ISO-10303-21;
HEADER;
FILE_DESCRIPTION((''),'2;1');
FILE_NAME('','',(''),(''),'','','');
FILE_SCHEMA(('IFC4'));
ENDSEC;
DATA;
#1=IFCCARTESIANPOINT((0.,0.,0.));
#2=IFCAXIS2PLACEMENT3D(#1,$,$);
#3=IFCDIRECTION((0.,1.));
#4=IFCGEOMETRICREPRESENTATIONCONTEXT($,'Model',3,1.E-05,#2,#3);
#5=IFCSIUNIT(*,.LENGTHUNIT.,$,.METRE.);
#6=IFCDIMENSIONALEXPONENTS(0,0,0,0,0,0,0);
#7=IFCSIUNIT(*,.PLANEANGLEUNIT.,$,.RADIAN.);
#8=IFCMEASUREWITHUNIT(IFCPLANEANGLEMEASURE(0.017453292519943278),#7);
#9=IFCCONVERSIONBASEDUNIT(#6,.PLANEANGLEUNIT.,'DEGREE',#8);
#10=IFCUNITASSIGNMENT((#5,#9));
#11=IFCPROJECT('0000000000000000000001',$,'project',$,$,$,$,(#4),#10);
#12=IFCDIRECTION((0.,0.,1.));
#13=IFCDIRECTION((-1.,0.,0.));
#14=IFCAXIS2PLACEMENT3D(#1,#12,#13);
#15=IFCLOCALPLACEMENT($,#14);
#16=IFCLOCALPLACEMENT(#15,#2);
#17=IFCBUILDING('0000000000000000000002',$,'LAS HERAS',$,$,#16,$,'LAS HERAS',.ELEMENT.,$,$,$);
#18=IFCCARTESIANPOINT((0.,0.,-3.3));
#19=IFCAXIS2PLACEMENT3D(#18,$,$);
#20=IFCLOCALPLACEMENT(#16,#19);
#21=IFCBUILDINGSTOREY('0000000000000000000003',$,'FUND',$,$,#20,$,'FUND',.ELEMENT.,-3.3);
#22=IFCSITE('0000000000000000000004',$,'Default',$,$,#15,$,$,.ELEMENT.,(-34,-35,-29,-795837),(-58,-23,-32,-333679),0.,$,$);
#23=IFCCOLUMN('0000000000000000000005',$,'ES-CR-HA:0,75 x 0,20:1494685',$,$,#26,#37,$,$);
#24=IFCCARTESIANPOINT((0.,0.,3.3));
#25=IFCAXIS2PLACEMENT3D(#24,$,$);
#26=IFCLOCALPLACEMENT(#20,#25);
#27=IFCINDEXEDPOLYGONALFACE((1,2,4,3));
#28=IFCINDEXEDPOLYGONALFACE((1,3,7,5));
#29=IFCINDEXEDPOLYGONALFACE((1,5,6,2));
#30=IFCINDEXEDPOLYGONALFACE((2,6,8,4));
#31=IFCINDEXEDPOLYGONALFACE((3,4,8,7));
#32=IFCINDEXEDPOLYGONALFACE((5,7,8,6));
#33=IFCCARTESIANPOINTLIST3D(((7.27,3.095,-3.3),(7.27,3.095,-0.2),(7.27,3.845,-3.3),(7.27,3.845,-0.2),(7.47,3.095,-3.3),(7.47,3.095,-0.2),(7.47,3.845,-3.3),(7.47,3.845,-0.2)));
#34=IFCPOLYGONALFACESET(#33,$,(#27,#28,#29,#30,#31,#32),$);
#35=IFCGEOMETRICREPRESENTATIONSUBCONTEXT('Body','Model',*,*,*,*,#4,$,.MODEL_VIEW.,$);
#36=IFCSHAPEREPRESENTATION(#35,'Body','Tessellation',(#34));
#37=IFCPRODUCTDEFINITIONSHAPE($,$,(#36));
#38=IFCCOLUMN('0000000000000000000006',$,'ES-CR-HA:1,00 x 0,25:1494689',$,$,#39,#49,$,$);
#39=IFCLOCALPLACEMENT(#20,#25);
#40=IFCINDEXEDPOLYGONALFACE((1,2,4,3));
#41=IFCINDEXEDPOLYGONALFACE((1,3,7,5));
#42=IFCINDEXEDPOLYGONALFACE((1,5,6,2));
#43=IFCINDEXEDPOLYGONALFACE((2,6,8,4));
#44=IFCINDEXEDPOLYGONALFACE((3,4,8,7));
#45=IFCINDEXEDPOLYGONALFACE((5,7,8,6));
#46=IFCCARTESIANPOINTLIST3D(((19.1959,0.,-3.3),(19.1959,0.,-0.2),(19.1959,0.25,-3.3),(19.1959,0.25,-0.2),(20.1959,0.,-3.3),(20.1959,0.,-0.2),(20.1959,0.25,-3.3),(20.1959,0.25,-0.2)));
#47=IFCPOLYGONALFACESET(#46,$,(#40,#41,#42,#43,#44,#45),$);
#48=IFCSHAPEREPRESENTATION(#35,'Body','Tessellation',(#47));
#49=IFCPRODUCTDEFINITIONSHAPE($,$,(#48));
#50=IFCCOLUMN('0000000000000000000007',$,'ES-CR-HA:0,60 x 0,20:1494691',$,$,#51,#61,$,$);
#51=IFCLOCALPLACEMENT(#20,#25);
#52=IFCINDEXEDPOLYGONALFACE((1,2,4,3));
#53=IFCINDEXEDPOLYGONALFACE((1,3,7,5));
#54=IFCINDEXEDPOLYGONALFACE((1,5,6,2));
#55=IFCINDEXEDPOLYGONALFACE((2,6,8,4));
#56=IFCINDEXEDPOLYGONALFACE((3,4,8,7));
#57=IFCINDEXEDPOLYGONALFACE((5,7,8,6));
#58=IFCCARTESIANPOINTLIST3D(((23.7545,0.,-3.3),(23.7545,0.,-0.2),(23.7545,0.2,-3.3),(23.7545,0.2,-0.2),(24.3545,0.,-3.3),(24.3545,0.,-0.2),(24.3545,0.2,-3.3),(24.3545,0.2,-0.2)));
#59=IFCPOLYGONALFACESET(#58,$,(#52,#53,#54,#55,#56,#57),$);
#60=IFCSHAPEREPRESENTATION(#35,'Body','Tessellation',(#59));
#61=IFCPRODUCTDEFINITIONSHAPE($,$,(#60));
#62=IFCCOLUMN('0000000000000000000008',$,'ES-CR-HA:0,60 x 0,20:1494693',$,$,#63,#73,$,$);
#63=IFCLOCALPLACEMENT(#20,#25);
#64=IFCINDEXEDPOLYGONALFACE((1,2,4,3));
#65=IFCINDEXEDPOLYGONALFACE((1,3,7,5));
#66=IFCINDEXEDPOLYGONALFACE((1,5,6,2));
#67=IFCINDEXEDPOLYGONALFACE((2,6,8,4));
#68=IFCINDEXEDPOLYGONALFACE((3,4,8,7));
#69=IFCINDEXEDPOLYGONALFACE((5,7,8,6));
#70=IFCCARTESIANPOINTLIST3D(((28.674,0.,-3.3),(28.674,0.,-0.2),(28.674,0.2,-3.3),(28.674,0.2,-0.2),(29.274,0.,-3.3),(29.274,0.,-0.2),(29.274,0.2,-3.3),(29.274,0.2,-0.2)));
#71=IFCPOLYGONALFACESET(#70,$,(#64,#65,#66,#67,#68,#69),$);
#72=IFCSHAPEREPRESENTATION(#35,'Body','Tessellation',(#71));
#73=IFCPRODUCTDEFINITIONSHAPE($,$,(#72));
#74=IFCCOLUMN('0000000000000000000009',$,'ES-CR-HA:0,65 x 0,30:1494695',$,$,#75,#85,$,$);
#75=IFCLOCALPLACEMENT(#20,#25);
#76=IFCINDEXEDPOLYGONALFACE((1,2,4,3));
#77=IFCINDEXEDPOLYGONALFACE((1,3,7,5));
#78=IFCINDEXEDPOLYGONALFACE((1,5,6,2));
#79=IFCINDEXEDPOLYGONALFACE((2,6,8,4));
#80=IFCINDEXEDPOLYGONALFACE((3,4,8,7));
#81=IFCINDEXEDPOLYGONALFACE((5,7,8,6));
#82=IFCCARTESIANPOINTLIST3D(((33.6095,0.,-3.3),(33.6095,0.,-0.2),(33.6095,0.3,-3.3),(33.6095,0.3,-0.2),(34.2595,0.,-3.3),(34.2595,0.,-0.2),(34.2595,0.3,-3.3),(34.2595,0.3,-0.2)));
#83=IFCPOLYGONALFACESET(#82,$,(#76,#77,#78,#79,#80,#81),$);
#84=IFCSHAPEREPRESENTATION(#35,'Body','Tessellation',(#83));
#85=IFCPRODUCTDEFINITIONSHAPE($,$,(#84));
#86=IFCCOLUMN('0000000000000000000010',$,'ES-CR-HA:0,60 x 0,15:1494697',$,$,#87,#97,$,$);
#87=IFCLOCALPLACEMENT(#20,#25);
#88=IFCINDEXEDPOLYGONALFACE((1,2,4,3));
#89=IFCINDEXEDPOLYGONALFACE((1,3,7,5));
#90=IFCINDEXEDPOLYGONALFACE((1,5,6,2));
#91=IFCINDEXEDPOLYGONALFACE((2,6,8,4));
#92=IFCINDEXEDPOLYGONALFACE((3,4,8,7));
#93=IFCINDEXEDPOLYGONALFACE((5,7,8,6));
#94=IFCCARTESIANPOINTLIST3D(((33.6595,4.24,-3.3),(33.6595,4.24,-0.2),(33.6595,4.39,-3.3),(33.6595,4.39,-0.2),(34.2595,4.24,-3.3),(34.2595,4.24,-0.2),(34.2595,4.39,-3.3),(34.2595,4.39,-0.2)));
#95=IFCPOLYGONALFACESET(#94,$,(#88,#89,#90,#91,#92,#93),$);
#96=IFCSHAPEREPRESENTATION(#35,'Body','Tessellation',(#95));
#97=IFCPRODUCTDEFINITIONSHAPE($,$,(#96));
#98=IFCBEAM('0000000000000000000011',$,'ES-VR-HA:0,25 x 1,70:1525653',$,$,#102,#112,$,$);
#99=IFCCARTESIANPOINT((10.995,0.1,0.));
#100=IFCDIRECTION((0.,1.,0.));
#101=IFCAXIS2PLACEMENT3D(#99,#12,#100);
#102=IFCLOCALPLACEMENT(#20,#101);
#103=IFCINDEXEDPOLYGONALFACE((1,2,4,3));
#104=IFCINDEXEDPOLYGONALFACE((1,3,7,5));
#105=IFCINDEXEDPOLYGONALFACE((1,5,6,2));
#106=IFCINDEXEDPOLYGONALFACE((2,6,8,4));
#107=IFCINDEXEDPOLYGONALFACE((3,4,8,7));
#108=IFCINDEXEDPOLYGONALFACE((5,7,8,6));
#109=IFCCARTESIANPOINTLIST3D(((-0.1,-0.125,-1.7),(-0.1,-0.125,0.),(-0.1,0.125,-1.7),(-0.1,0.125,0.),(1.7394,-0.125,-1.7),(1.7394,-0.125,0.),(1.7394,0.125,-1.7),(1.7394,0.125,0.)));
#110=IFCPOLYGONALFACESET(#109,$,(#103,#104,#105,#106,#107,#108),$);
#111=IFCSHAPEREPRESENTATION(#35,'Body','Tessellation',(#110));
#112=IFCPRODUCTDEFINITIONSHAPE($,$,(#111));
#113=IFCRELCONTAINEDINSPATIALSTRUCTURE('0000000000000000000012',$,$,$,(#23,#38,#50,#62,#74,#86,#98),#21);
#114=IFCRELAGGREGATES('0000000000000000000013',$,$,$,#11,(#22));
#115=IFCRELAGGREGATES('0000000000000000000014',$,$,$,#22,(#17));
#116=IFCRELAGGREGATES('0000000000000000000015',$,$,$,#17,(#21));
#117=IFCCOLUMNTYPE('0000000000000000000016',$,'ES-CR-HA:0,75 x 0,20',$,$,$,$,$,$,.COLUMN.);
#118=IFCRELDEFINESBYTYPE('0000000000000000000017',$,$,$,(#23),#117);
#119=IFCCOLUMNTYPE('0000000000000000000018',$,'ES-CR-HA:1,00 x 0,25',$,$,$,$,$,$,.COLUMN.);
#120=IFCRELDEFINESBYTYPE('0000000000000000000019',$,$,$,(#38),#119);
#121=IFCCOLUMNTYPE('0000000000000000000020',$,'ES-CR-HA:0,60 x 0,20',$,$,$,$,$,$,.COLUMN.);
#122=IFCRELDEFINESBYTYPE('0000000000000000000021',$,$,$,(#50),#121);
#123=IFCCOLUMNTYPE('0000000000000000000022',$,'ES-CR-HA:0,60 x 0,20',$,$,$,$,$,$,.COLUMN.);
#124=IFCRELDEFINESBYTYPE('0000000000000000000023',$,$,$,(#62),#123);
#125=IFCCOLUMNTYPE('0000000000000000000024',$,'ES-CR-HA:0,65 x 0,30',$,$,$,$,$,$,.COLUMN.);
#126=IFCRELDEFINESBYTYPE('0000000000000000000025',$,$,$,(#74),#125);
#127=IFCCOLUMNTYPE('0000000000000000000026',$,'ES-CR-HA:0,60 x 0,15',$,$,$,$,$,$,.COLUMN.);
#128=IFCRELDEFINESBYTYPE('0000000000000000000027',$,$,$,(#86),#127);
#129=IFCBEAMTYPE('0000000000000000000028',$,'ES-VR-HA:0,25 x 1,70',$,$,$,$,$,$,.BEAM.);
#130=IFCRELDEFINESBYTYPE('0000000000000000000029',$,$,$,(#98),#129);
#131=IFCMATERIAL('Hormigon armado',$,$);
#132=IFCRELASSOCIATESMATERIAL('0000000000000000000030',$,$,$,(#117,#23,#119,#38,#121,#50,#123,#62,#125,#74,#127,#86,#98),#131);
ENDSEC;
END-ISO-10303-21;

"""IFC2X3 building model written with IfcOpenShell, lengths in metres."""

from ifc_helpers import new_model, entity, si_unit, converted_unit, direction, frame, frame_2d, origin, origin_2d_with_axis, place, context, subcontext, project, spatial, rectangle, extrude, source, transform, mapped, material, type_object, type_shapes, element, save


model = new_model("IFC2X3")

# Units and contexts
model_context = context("Model", 3, precision=1e-05, world=origin(), true_north=direction((0.0, 1.0)))
body_context = subcontext(model_context, "Body", "Model", "MODEL_VIEW")
ifc_project = project(units=[si_unit("LENGTHUNIT", "METRE"), converted_unit("PLANEANGLEUNIT", "DEGREE", entity("IfcPlaneAngleMeasure", 0.017453292519943278), si_unit("PLANEANGLEUNIT", "RADIAN"), dimensions=[0, 0, 0, 0, 0, 0, 0])], contexts=[model_context])

# Site, building, storey
site_placement = place(None, frame((0.0, 0.0, 0.0), z_axis=(0.0, 0.0, 1.0), x_axis=(-1.0, 0.0, 0.0)))
site = spatial("IfcSite", under=ifc_project, at=site_placement, Name="Default", CompositionType="ELEMENT", RefLatitude=(-34, -35, -29, -795837), RefLongitude=(-58, -23, -32, -333679), RefElevation=0.0)
building_placement = place(site_placement, origin())
building = spatial("IfcBuilding", under=site, at=building_placement, Name="LAS HERAS", LongName="LAS HERAS", CompositionType="ELEMENT")
storey_placement = place(building_placement, frame((0.0, 0.0, -3.3)))
storey = spatial("IfcBuildingStorey", under=building, at=storey_placement, Name="FUND", LongName="FUND", CompositionType="ELEMENT", Elevation=-3.3)

# Columns
ifc_material = material(Name="Hormigon armado")
column_type_1 = type_object("IfcColumnType", Name="ES-CR-HA:0,75 x 0,20", PredefinedType="COLUMN", material=ifc_material)
shared_shape_1 = source(origin(), body_context, "Body", "SweptSolid", [
    extrude(rectangle(XDim=0.75, YDim=0.2, at=frame_2d((0.0, 0.0), x_axis=(1.0, 0.0))), frame((7.37, 3.47, -3.3), z_axis=(0.0, 0.0, 1.0), x_axis=(0.0, -1.0, 0.0)), (0.0, 0.0, 1.0), 3.1),
])
type_shapes(column_type_1, [shared_shape_1])
column_1_placement = place(storey_placement, frame((0.0, 0.0, 3.3)))
element("IfcColumn", 1, at=column_1_placement, inside=storey, type_object=column_type_1, material=ifc_material, Name="ES-CR-HA:0,75 x 0,20:1494685", context=body_context, shape_type="MappedRepresentation", body=[
    mapped(shared_shape_1, transform((0.0, 0.0, 0.0), scale=1.0)),
])
column_type_2 = type_object("IfcColumnType", Name="ES-CR-HA:1,00 x 0,25", PredefinedType="COLUMN", material=ifc_material)
shared_shape_2 = source(origin(), body_context, "Body", "SweptSolid", [
    extrude(rectangle(XDim=1.0, YDim=0.25, at=frame_2d((0.0, 0.0), x_axis=(1.0, 0.0))), frame((19.6959, 0.125, -3.3), z_axis=(0.0, 0.0, 1.0), x_axis=(-1.0, 0.0, 0.0)), (0.0, 0.0, 1.0), 3.1),
])
type_shapes(column_type_2, [shared_shape_2])
column_2_placement = place(storey_placement, frame((0.0, 0.0, 3.3)))
element("IfcColumn", 2, at=column_2_placement, inside=storey, type_object=column_type_2, material=ifc_material, Name="ES-CR-HA:1,00 x 0,25:1494689", context=body_context, shape_type="MappedRepresentation", body=[
    mapped(shared_shape_2, transform((0.0, 0.0, 0.0), scale=1.0)),
])
column_type_3 = type_object("IfcColumnType", Name="ES-CR-HA:0,60 x 0,20", PredefinedType="COLUMN", material=ifc_material)
shared_shape_3 = source(origin(), body_context, "Body", "SweptSolid", [
    extrude(rectangle(XDim=0.6, YDim=0.2, at=frame_2d((0.0, 0.0), x_axis=(1.0, 0.0))), frame((24.0545, 0.1, -3.3), z_axis=(0.0, 0.0, 1.0), x_axis=(-1.0, 0.0, 0.0)), (0.0, 0.0, 1.0), 3.1),
])
type_shapes(column_type_3, [shared_shape_3])
column_3_placement = place(storey_placement, frame((0.0, 0.0, 3.3)))
element("IfcColumn", 3, at=column_3_placement, inside=storey, type_object=column_type_3, material=ifc_material, Name="ES-CR-HA:0,60 x 0,20:1494691", context=body_context, shape_type="MappedRepresentation", body=[
    mapped(shared_shape_3, transform((0.0, 0.0, 0.0), scale=1.0)),
])
column_type_4 = type_object("IfcColumnType", Name="ES-CR-HA:0,60 x 0,20", PredefinedType="COLUMN", material=ifc_material)
shared_shape_4 = source(origin(), body_context, "Body", "SweptSolid", [
    extrude(rectangle(XDim=0.6, YDim=0.2, at=frame_2d((0.0, 0.0), x_axis=(1.0, 0.0))), frame((28.974, 0.1, -3.3), z_axis=(0.0, 0.0, 1.0), x_axis=(-1.0, 0.0, 0.0)), (0.0, 0.0, 1.0), 3.1),
])
type_shapes(column_type_4, [shared_shape_4])
column_4_placement = place(storey_placement, frame((0.0, 0.0, 3.3)))
element("IfcColumn", 4, at=column_4_placement, inside=storey, type_object=column_type_4, material=ifc_material, Name="ES-CR-HA:0,60 x 0,20:1494693", context=body_context, shape_type="MappedRepresentation", body=[
    mapped(shared_shape_4, transform((0.0, 0.0, 0.0), scale=1.0)),
])
column_type_5 = type_object("IfcColumnType", Name="ES-CR-HA:0,65 x 0,30", PredefinedType="COLUMN", material=ifc_material)
shared_shape_5 = source(origin(), body_context, "Body", "SweptSolid", [
    extrude(rectangle(XDim=0.65, YDim=0.3, at=origin_2d_with_axis()), frame((33.9345, 0.15, -3.3), z_axis=(0.0, 0.0, 1.0), x_axis=(-1.0, 0.0, 0.0)), (0.0, 0.0, 1.0), 3.1),
])
type_shapes(column_type_5, [shared_shape_5])
column_5_placement = place(storey_placement, frame((0.0, 0.0, 3.3)))
element("IfcColumn", 5, at=column_5_placement, inside=storey, type_object=column_type_5, material=ifc_material, Name="ES-CR-HA:0,65 x 0,30:1494695", context=body_context, shape_type="MappedRepresentation", body=[
    mapped(shared_shape_5, transform((0.0, 0.0, 0.0), scale=1.0)),
])
column_type_6 = type_object("IfcColumnType", Name="ES-CR-HA:0,60 x 0,15", PredefinedType="COLUMN", material=ifc_material)
shared_shape_6 = source(origin(), body_context, "Body", "SweptSolid", [
    extrude(rectangle(XDim=0.6, YDim=0.15, at=frame_2d((0.0, 0.0), x_axis=(1.0, 0.0))), frame((33.9595, 4.315, -3.3), z_axis=(0.0, 0.0, 1.0), x_axis=(-1.0, 0.0, 0.0)), (0.0, 0.0, 1.0), 3.1),
])
type_shapes(column_type_6, [shared_shape_6])
column_6_placement = place(storey_placement, frame((0.0, 0.0, 3.3)))
element("IfcColumn", 6, at=column_6_placement, inside=storey, type_object=column_type_6, material=ifc_material, Name="ES-CR-HA:0,60 x 0,15:1494697", context=body_context, shape_type="MappedRepresentation", body=[
    mapped(shared_shape_6, transform((0.0, 0.0, 0.0), scale=1.0)),
])

# Beam
beam_type_1 = type_object("IfcBeamType", Name="ES-VR-HA:0,25 x 1,70", PredefinedType="BEAM")
beam_1_placement = place(storey_placement, frame((10.995, 0.1, 0.0), z_axis=(0.0, 0.0, 1.0), x_axis=(0.0, 1.0, 0.0)))
element("IfcBeam", 7, at=beam_1_placement, inside=storey, type_object=beam_type_1, material=ifc_material, Name="ES-VR-HA:0,25 x 1,70:1525653", context=body_context, shape_type="SweptSolid", body=[
    extrude(rectangle(XDim=1.7, YDim=0.25, at=origin_2d_with_axis()), frame((-0.1, 0.0, -0.85), z_axis=(1.0, 0.0, 0.0), x_axis=(0.0, 0.0, -1.0)), (0.0, 0.0, 1.0), 1.8394),
])

save(model, "model.ifc")
